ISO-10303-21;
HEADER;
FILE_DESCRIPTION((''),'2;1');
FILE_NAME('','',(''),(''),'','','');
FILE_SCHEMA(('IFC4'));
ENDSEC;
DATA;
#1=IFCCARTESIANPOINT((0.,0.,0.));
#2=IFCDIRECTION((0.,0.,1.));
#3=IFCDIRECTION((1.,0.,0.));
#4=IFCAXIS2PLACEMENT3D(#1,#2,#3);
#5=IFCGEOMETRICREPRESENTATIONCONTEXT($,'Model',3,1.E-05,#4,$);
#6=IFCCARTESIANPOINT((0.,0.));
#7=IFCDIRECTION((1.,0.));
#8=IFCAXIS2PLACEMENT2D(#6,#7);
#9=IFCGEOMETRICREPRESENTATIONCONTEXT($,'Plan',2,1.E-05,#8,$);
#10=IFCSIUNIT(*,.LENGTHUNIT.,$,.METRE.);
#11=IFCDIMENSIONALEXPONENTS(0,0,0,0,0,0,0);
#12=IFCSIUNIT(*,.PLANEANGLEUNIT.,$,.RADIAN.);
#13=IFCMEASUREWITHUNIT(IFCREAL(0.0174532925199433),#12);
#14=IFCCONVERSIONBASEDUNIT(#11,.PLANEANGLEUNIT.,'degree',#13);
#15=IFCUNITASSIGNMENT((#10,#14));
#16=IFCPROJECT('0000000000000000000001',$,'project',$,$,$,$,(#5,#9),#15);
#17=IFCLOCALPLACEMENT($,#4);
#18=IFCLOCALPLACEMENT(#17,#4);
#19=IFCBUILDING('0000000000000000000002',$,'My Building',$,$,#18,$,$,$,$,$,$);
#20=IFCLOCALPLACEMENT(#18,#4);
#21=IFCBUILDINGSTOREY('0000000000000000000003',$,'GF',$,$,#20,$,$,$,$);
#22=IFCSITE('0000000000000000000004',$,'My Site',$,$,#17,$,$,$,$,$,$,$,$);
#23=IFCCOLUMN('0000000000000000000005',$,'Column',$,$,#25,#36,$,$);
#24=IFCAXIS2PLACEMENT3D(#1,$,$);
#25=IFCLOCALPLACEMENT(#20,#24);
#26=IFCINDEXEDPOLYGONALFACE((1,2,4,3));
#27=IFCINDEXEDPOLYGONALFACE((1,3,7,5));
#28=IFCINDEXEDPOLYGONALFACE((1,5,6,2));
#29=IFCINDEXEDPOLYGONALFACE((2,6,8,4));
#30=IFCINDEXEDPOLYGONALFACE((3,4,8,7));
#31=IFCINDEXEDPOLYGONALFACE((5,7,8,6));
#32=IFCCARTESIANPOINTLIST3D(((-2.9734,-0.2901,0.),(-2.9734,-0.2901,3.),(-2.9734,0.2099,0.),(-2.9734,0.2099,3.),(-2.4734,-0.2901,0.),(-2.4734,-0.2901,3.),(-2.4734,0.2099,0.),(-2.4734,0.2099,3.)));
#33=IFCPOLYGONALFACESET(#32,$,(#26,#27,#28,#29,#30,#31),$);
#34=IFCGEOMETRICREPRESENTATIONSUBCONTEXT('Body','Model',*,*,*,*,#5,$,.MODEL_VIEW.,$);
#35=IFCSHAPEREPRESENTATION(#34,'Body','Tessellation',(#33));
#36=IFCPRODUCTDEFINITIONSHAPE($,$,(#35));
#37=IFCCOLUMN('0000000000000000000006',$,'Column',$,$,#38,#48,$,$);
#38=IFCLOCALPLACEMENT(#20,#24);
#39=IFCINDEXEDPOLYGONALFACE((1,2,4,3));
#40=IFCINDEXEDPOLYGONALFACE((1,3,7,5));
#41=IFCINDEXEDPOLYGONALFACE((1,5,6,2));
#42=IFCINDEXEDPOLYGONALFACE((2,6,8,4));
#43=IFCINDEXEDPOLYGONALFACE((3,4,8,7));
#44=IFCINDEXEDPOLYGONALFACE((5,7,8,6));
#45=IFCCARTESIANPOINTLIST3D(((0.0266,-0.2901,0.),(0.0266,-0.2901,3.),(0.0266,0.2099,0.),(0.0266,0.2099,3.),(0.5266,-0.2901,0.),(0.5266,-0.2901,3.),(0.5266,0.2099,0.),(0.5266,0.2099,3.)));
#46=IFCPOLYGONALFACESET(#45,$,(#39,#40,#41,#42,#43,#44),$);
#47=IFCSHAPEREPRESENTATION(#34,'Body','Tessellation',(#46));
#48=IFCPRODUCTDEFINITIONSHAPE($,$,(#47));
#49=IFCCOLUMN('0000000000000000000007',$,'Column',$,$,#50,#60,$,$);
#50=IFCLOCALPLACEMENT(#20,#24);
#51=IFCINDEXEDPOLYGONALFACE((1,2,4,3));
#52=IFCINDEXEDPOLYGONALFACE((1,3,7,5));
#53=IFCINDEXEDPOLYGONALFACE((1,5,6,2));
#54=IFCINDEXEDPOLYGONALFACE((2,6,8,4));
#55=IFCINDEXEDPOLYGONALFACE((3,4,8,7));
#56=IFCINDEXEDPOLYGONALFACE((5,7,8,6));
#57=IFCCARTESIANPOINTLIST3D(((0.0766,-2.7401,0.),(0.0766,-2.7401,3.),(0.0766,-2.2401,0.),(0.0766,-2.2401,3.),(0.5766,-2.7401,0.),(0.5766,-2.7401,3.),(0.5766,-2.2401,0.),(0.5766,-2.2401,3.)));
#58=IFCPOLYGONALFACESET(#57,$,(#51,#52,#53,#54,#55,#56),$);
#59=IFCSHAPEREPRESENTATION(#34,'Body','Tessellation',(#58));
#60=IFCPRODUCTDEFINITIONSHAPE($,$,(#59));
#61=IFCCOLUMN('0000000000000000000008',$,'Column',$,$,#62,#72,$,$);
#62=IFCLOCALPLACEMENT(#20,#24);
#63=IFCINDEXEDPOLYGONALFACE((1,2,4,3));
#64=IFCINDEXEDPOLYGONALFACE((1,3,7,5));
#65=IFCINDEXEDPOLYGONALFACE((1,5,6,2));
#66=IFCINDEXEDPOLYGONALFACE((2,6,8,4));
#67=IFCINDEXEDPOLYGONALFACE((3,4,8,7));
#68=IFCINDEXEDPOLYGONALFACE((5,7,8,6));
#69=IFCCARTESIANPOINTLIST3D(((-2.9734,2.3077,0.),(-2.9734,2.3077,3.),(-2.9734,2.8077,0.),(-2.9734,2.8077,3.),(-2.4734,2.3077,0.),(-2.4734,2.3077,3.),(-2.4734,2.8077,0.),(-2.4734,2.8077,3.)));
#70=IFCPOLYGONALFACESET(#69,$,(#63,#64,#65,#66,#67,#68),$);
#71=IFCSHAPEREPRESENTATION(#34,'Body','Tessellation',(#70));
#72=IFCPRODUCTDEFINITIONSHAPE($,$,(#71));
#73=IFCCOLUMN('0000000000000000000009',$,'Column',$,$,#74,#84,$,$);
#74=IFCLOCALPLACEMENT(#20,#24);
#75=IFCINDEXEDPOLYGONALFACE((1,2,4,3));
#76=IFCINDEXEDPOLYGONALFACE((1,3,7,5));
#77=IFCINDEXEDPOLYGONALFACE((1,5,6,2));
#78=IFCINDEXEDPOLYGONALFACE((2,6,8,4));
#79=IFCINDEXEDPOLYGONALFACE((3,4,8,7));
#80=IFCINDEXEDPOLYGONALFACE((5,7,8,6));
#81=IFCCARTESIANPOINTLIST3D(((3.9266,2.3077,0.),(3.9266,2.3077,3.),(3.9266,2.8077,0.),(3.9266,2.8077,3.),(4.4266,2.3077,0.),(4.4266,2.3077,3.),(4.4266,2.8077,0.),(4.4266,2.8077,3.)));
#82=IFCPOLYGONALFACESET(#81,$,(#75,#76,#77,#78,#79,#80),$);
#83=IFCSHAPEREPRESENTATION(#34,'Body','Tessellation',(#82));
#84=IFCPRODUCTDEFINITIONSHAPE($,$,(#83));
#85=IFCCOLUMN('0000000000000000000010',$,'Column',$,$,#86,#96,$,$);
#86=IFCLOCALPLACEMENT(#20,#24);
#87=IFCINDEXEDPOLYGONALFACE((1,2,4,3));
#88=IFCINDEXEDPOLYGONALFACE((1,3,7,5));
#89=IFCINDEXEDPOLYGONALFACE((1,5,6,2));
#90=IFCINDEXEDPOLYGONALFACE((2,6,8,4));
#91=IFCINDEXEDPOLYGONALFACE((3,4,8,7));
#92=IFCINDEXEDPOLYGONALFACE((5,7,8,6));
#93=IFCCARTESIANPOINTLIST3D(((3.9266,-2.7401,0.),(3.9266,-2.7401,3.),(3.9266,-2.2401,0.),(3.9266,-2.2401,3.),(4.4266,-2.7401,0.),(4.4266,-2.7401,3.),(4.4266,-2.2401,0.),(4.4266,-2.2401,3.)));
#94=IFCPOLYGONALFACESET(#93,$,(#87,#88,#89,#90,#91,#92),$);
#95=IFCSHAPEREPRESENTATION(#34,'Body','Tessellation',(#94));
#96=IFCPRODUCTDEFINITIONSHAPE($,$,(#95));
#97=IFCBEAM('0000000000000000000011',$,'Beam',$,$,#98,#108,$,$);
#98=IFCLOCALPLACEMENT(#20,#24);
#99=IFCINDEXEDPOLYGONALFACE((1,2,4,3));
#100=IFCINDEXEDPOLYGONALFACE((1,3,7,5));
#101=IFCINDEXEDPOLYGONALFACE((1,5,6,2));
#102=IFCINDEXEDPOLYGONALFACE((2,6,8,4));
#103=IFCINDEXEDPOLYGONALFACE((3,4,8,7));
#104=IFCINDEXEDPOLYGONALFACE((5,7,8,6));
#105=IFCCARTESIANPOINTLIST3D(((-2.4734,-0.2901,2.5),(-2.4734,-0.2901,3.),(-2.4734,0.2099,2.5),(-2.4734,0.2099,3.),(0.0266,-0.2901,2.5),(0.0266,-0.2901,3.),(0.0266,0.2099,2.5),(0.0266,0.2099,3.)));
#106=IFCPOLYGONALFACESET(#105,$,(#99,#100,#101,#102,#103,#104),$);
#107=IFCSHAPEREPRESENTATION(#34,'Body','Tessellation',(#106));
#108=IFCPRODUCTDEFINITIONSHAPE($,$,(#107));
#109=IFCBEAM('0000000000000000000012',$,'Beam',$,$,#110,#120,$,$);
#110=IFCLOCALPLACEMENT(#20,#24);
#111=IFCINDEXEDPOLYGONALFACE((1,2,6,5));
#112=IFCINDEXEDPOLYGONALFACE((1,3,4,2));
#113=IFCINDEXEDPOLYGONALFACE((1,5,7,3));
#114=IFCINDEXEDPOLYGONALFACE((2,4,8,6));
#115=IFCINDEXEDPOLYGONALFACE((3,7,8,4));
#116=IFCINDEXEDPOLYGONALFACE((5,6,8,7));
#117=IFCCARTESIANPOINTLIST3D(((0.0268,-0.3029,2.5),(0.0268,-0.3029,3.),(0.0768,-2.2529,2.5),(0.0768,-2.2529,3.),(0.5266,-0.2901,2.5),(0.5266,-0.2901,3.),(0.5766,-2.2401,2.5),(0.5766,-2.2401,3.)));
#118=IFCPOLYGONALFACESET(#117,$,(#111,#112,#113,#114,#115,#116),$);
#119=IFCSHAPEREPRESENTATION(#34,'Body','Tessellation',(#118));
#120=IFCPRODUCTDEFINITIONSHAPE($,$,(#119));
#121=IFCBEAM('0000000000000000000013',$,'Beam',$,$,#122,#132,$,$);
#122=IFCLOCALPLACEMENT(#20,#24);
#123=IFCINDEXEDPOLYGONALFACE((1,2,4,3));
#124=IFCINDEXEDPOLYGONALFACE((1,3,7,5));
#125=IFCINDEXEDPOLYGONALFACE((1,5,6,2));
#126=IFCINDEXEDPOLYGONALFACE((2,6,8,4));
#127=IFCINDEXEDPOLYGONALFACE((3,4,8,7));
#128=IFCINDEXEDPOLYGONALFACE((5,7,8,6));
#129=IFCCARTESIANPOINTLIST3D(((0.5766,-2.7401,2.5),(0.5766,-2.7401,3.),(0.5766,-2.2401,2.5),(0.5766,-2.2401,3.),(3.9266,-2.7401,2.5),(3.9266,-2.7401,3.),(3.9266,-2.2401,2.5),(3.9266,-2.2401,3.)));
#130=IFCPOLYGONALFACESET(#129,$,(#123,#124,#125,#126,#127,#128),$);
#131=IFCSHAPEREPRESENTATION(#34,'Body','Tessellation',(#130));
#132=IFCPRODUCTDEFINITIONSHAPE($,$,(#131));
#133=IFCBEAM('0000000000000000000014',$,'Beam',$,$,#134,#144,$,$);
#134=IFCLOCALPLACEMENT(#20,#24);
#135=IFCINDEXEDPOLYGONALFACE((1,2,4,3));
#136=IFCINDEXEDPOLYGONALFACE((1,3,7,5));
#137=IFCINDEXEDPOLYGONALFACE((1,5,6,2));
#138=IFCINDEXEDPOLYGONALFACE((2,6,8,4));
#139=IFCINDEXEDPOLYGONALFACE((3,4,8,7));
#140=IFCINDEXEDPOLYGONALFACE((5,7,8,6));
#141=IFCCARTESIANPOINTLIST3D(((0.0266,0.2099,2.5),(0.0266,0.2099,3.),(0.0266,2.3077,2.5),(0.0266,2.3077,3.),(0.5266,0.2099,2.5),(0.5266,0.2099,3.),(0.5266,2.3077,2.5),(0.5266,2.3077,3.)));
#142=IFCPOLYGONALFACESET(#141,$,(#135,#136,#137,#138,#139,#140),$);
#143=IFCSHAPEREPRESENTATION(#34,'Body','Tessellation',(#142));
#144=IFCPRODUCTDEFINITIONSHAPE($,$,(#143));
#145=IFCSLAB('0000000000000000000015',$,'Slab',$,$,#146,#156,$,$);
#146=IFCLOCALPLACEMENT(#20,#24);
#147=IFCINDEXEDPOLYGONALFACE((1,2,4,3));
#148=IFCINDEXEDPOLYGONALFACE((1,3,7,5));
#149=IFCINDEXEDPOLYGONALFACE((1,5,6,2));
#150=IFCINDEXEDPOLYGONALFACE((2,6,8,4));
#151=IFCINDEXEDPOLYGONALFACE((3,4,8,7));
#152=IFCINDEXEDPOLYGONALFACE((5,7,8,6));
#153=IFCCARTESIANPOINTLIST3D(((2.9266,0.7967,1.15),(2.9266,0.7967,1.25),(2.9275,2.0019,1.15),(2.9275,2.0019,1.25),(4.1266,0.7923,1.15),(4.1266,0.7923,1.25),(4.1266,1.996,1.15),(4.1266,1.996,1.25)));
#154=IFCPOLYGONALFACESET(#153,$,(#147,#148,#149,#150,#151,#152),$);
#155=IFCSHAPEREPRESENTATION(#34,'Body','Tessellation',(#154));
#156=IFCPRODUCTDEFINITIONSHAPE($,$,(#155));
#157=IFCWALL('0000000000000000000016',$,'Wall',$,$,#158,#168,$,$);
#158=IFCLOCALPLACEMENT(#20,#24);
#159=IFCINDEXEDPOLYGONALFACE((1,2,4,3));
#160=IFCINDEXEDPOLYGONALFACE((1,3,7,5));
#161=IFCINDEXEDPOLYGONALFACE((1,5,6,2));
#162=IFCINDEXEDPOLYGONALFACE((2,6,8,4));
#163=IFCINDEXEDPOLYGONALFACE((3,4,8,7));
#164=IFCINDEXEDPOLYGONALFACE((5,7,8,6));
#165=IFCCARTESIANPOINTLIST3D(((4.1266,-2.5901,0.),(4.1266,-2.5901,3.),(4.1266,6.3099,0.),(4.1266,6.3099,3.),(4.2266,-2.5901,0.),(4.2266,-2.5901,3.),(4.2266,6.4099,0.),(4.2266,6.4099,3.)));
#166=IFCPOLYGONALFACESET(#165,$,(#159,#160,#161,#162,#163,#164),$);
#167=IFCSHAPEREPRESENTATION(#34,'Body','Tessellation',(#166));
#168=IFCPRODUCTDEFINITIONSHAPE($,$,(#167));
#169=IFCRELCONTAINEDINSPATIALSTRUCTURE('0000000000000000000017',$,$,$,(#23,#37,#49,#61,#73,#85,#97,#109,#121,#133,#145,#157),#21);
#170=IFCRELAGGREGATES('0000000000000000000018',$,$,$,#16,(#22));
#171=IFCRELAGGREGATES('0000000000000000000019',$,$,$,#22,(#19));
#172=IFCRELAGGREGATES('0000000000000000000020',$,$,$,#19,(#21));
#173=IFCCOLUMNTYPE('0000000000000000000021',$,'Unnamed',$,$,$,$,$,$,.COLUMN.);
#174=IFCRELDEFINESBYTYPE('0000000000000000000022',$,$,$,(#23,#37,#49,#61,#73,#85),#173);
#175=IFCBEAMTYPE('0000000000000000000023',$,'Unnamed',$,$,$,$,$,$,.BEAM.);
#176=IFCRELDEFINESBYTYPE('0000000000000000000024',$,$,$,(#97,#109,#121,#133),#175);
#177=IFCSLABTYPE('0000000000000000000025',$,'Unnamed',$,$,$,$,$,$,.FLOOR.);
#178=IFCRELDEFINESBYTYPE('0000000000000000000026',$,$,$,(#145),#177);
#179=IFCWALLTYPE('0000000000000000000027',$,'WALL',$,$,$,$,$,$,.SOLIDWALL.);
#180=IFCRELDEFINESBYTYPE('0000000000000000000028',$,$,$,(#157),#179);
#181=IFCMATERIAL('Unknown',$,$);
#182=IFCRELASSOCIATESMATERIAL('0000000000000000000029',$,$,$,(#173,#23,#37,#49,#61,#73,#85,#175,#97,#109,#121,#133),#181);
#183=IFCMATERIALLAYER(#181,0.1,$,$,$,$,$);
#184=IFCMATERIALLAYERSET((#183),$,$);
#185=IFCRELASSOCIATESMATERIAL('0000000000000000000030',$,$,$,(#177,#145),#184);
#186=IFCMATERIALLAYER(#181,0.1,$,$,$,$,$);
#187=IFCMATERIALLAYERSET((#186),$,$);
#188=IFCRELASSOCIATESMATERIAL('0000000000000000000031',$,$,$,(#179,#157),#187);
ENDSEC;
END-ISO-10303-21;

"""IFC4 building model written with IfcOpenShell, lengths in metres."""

from ifc_helpers import new_model, entity, si_unit, converted_unit, frame, origin_with_axes, origin_2d_with_axis, place, context, subcontext, project, spatial, line, indexed_curve, rectangle, outline, extrude, material, layer, layer_set, layer_usage, material_profile, profile_set, profile_usage, type_object, element, save


model = new_model("IFC4")

# Units and contexts
model_context = context("Model", 3, precision=1e-05, world=origin_with_axes())
plan_context = context("Plan", 2, precision=1e-05, world=origin_2d_with_axis())
body_context_1 = subcontext(model_context, "Body", "Model", "MODEL_VIEW")
ifc_project = project(units=[si_unit("LENGTHUNIT", "METRE"), converted_unit("PLANEANGLEUNIT", "degree", entity("IfcReal", 0.0174532925199433), si_unit("PLANEANGLEUNIT", "RADIAN"), dimensions=[0, 0, 0, 0, 0, 0, 0])], contexts=[model_context, plan_context])

# Site, building, storey
site_placement = place(None, origin_with_axes())
site = spatial("IfcSite", under=ifc_project, at=site_placement, Name="My Site")
building_placement = place(site_placement, origin_with_axes())
building = spatial("IfcBuilding", under=site, at=building_placement, Name="My Building")
storey_placement = place(building_placement, origin_with_axes())
storey = spatial("IfcBuildingStorey", under=building, at=storey_placement, Name="GF")

# Columns
ifc_material_1 = material(Name="Unknown")
ifc_material_profile_1 = material_profile(ifc_material_1, rectangle(XDim=0.5, YDim=0.5))
ifc_profile_set_1 = profile_set([ifc_material_profile_1])
ifc_profile_usage_1 = profile_usage(ifc_profile_set_1, cardinal=5)
column_type = type_object("IfcColumnType", Name="Unnamed", PredefinedType="COLUMN", material=ifc_profile_set_1)
column_1_placement = place(storey_placement, frame((-2.7234, -0.0401, 0.0), z_axis=(0.0, 0.0, 1.0), x_axis=(1.0, 0.0, 0.0)))
element("IfcColumn", 1, at=column_1_placement, inside=storey, type_object=column_type, material=ifc_profile_usage_1, Name="Column", context=body_context_1, shape_type="SweptSolid", body=[
    extrude(rectangle(XDim=0.5, YDim=0.5), origin_with_axes(), (0.0, 0.0, 1.0), 3.0),
])
ifc_profile_usage_2 = profile_usage(ifc_profile_set_1, cardinal=5)
column_2_placement = place(storey_placement, frame((0.2766, -0.0401, 0.0), z_axis=(0.0, 0.0, 1.0), x_axis=(1.0, 0.0, 0.0)))
element("IfcColumn", 2, at=column_2_placement, inside=storey, type_object=column_type, material=ifc_profile_usage_2, Name="Column", context=body_context_1, shape_type="SweptSolid", body=[
    extrude(rectangle(XDim=0.5, YDim=0.5), origin_with_axes(), (0.0, 0.0, 1.0), 3.0),
])
ifc_profile_usage_3 = profile_usage(ifc_profile_set_1, cardinal=5)
column_3_placement = place(storey_placement, frame((0.3266, -2.4901, 0.0), z_axis=(0.0, 0.0, 1.0), x_axis=(1.0, 0.0, 0.0)))
element("IfcColumn", 3, at=column_3_placement, inside=storey, type_object=column_type, material=ifc_profile_usage_3, Name="Column", context=body_context_1, shape_type="SweptSolid", body=[
    extrude(rectangle(XDim=0.5, YDim=0.5), origin_with_axes(), (0.0, 0.0, 1.0), 3.0),
])
ifc_profile_usage_4 = profile_usage(ifc_profile_set_1, cardinal=5)
column_4_placement = place(storey_placement, frame((-2.7234, 2.5577, 0.0), z_axis=(0.0, 0.0, 1.0), x_axis=(1.0, 0.0, 0.0)))
element("IfcColumn", 4, at=column_4_placement, inside=storey, type_object=column_type, material=ifc_profile_usage_4, Name="Column", context=body_context_1, shape_type="SweptSolid", body=[
    extrude(rectangle(XDim=0.5, YDim=0.5), origin_with_axes(), (0.0, 0.0, 1.0), 3.0),
])
ifc_profile_usage_5 = profile_usage(ifc_profile_set_1, cardinal=5)
column_5_placement = place(storey_placement, frame((4.1766, 2.5577, 0.0), z_axis=(0.0, 0.0, 1.0), x_axis=(1.0, 0.0, 0.0)))
element("IfcColumn", 5, at=column_5_placement, inside=storey, type_object=column_type, material=ifc_profile_usage_5, Name="Column", context=body_context_1, shape_type="SweptSolid", body=[
    extrude(rectangle(XDim=0.5, YDim=0.5), origin_with_axes(), (0.0, 0.0, 1.0), 3.0),
])
ifc_profile_usage_6 = profile_usage(ifc_profile_set_1, cardinal=5)
column_6_placement = place(storey_placement, frame((4.1766, -2.4901, 0.0), z_axis=(0.0, 0.0, 1.0), x_axis=(1.0, 0.0, 0.0)))
element("IfcColumn", 6, at=column_6_placement, inside=storey, type_object=column_type, material=ifc_profile_usage_6, Name="Column", context=body_context_1, shape_type="SweptSolid", body=[
    extrude(rectangle(XDim=0.5, YDim=0.5), origin_with_axes(), (0.0, 0.0, 1.0), 3.0),
])

# Beams
ifc_material_profile_2 = material_profile(ifc_material_1, rectangle(XDim=0.5, YDim=0.5))
ifc_profile_set_2 = profile_set([ifc_material_profile_2])
ifc_profile_usage_7 = profile_usage(ifc_profile_set_2, cardinal=7)
beam_type = type_object("IfcBeamType", Name="Unnamed", PredefinedType="BEAM", material=ifc_profile_set_2)
beam_1_placement = place(storey_placement, frame((-2.4734, 0.2099, 3.0), z_axis=(1.0, 0.0, 0.0), x_axis=(0.0, 1.0, 0.0)))
element("IfcBeam", 7, at=beam_1_placement, inside=storey, type_object=beam_type, material=ifc_profile_usage_7, Name="Beam", context=body_context_1, shape_type="SweptSolid", body=[
    extrude(rectangle(XDim=0.5, YDim=0.5), frame((-0.25, -0.25, 0.0), z_axis=(0.0, 0.0, 1.0), x_axis=(1.0, 0.0, 0.0)), (0.0, 0.0, 1.0), 2.5),
])
ifc_profile_usage_8 = profile_usage(ifc_profile_set_2, cardinal=7)
beam_2_placement = place(storey_placement, frame((0.5266, -0.2901, 3.0), z_axis=(0.025633, -0.999671, 0.0), x_axis=(0.999671, 0.025633, 0.0)))
element("IfcBeam", 8, at=beam_2_placement, inside=storey, type_object=beam_type, material=ifc_profile_usage_8, Name="Beam", context=body_context_1, shape_type="SweptSolid", body=[
    extrude(rectangle(XDim=0.5, YDim=0.5), frame((-0.25, -0.25, 0.0), z_axis=(0.0, 0.0, 1.0), x_axis=(1.0, 0.0, 0.0)), (0.0, 0.0, 1.0), 1.9506),
])
ifc_profile_usage_9 = profile_usage(ifc_profile_set_2, cardinal=7)
beam_3_placement = place(storey_placement, frame((0.5766, -2.2401, 3.0), z_axis=(1.0, 0.0, 0.0), x_axis=(0.0, 1.0, 0.0)))
element("IfcBeam", 9, at=beam_3_placement, inside=storey, type_object=beam_type, material=ifc_profile_usage_9, Name="Beam", context=body_context_1, shape_type="SweptSolid", body=[
    extrude(rectangle(XDim=0.5, YDim=0.5), frame((-0.25, -0.25, 0.0), z_axis=(0.0, 0.0, 1.0), x_axis=(1.0, 0.0, 0.0)), (0.0, 0.0, 1.0), 3.35),
])
ifc_profile_usage_10 = profile_usage(ifc_profile_set_2, cardinal=7)
beam_4_placement = place(storey_placement, frame((0.5266, 2.3077, 3.0), z_axis=(0.0, -1.0, 0.0), x_axis=(1.0, 0.0, 0.0)))
element("IfcBeam", 10, at=beam_4_placement, inside=storey, type_object=beam_type, material=ifc_profile_usage_10, Name="Beam", context=body_context_1, shape_type="SweptSolid", body=[
    extrude(rectangle(XDim=0.5, YDim=0.5), frame((-0.25, -0.25, 0.0), z_axis=(0.0, 0.0, 1.0), x_axis=(1.0, 0.0, 0.0)), (0.0, 0.0, 1.0), 2.0978),
])

# Slab
ifc_layer_1 = layer(ifc_material_1, 0.1)
ifc_layer_set_1 = layer_set([ifc_layer_1])
ifc_layer_usage_1 = layer_usage(ifc_layer_set_1, "AXIS3", "POSITIVE", -0.1)
slab_type = type_object("IfcSlabType", Name="Unnamed", PredefinedType="FLOOR", material=ifc_layer_set_1)
slab_placement = place(storey_placement, frame((2.9266, 0.7967, 1.25), z_axis=(0.0, 0.0, 1.0), x_axis=(1.0, 0.0, 0.0)))
element("IfcSlab", 11, at=slab_placement, inside=storey, type_object=slab_type, material=ifc_layer_usage_1, Name="Slab", context=body_context_1, shape_type="SweptSolid", body=[
    extrude(outline(indexed_curve([(0.0, 0.0), (1.2, -0.0044), (1.2, 1.1993), (0.0009, 1.2051), (0.0, 0.0)])), frame((0.0, 0.0, -0.1), z_axis=(0.0, 0.0, 1.0), x_axis=(1.0, 0.0, 0.0)), (0.0, 0.0, 1.0), 0.1),
])

# Wall
ifc_layer_2 = layer(ifc_material_1, 0.1)
ifc_layer_set_2 = layer_set([ifc_layer_2])
ifc_layer_usage_2 = layer_usage(ifc_layer_set_2, "AXIS2", "POSITIVE", 0.0)
wall_type = type_object("IfcWallType", Name="WALL", PredefinedType="SOLIDWALL", material=ifc_layer_set_2)
wall_1_placement = place(storey_placement, frame((4.2266, -2.5901, 0.0), z_axis=(0.0, 0.0, 1.0), x_axis=(0.0, 1.0, 0.0)))
element("IfcWall", 12, at=wall_1_placement, inside=storey, type_object=wall_type, material=ifc_layer_usage_2, Name="Wall", context=body_context_1, shape_type="SweptSolid", body=[
    extrude(outline(indexed_curve([(0.0, 0.0), (0.0, 0.1), (8.9, 0.1), (9.0, 0.0)], segments=[line(1, 2, 3, 4, 1)])), origin_with_axes(), (0.0, 0.0, 1.0), 3.0),
])

save(model, "model.ifc")
